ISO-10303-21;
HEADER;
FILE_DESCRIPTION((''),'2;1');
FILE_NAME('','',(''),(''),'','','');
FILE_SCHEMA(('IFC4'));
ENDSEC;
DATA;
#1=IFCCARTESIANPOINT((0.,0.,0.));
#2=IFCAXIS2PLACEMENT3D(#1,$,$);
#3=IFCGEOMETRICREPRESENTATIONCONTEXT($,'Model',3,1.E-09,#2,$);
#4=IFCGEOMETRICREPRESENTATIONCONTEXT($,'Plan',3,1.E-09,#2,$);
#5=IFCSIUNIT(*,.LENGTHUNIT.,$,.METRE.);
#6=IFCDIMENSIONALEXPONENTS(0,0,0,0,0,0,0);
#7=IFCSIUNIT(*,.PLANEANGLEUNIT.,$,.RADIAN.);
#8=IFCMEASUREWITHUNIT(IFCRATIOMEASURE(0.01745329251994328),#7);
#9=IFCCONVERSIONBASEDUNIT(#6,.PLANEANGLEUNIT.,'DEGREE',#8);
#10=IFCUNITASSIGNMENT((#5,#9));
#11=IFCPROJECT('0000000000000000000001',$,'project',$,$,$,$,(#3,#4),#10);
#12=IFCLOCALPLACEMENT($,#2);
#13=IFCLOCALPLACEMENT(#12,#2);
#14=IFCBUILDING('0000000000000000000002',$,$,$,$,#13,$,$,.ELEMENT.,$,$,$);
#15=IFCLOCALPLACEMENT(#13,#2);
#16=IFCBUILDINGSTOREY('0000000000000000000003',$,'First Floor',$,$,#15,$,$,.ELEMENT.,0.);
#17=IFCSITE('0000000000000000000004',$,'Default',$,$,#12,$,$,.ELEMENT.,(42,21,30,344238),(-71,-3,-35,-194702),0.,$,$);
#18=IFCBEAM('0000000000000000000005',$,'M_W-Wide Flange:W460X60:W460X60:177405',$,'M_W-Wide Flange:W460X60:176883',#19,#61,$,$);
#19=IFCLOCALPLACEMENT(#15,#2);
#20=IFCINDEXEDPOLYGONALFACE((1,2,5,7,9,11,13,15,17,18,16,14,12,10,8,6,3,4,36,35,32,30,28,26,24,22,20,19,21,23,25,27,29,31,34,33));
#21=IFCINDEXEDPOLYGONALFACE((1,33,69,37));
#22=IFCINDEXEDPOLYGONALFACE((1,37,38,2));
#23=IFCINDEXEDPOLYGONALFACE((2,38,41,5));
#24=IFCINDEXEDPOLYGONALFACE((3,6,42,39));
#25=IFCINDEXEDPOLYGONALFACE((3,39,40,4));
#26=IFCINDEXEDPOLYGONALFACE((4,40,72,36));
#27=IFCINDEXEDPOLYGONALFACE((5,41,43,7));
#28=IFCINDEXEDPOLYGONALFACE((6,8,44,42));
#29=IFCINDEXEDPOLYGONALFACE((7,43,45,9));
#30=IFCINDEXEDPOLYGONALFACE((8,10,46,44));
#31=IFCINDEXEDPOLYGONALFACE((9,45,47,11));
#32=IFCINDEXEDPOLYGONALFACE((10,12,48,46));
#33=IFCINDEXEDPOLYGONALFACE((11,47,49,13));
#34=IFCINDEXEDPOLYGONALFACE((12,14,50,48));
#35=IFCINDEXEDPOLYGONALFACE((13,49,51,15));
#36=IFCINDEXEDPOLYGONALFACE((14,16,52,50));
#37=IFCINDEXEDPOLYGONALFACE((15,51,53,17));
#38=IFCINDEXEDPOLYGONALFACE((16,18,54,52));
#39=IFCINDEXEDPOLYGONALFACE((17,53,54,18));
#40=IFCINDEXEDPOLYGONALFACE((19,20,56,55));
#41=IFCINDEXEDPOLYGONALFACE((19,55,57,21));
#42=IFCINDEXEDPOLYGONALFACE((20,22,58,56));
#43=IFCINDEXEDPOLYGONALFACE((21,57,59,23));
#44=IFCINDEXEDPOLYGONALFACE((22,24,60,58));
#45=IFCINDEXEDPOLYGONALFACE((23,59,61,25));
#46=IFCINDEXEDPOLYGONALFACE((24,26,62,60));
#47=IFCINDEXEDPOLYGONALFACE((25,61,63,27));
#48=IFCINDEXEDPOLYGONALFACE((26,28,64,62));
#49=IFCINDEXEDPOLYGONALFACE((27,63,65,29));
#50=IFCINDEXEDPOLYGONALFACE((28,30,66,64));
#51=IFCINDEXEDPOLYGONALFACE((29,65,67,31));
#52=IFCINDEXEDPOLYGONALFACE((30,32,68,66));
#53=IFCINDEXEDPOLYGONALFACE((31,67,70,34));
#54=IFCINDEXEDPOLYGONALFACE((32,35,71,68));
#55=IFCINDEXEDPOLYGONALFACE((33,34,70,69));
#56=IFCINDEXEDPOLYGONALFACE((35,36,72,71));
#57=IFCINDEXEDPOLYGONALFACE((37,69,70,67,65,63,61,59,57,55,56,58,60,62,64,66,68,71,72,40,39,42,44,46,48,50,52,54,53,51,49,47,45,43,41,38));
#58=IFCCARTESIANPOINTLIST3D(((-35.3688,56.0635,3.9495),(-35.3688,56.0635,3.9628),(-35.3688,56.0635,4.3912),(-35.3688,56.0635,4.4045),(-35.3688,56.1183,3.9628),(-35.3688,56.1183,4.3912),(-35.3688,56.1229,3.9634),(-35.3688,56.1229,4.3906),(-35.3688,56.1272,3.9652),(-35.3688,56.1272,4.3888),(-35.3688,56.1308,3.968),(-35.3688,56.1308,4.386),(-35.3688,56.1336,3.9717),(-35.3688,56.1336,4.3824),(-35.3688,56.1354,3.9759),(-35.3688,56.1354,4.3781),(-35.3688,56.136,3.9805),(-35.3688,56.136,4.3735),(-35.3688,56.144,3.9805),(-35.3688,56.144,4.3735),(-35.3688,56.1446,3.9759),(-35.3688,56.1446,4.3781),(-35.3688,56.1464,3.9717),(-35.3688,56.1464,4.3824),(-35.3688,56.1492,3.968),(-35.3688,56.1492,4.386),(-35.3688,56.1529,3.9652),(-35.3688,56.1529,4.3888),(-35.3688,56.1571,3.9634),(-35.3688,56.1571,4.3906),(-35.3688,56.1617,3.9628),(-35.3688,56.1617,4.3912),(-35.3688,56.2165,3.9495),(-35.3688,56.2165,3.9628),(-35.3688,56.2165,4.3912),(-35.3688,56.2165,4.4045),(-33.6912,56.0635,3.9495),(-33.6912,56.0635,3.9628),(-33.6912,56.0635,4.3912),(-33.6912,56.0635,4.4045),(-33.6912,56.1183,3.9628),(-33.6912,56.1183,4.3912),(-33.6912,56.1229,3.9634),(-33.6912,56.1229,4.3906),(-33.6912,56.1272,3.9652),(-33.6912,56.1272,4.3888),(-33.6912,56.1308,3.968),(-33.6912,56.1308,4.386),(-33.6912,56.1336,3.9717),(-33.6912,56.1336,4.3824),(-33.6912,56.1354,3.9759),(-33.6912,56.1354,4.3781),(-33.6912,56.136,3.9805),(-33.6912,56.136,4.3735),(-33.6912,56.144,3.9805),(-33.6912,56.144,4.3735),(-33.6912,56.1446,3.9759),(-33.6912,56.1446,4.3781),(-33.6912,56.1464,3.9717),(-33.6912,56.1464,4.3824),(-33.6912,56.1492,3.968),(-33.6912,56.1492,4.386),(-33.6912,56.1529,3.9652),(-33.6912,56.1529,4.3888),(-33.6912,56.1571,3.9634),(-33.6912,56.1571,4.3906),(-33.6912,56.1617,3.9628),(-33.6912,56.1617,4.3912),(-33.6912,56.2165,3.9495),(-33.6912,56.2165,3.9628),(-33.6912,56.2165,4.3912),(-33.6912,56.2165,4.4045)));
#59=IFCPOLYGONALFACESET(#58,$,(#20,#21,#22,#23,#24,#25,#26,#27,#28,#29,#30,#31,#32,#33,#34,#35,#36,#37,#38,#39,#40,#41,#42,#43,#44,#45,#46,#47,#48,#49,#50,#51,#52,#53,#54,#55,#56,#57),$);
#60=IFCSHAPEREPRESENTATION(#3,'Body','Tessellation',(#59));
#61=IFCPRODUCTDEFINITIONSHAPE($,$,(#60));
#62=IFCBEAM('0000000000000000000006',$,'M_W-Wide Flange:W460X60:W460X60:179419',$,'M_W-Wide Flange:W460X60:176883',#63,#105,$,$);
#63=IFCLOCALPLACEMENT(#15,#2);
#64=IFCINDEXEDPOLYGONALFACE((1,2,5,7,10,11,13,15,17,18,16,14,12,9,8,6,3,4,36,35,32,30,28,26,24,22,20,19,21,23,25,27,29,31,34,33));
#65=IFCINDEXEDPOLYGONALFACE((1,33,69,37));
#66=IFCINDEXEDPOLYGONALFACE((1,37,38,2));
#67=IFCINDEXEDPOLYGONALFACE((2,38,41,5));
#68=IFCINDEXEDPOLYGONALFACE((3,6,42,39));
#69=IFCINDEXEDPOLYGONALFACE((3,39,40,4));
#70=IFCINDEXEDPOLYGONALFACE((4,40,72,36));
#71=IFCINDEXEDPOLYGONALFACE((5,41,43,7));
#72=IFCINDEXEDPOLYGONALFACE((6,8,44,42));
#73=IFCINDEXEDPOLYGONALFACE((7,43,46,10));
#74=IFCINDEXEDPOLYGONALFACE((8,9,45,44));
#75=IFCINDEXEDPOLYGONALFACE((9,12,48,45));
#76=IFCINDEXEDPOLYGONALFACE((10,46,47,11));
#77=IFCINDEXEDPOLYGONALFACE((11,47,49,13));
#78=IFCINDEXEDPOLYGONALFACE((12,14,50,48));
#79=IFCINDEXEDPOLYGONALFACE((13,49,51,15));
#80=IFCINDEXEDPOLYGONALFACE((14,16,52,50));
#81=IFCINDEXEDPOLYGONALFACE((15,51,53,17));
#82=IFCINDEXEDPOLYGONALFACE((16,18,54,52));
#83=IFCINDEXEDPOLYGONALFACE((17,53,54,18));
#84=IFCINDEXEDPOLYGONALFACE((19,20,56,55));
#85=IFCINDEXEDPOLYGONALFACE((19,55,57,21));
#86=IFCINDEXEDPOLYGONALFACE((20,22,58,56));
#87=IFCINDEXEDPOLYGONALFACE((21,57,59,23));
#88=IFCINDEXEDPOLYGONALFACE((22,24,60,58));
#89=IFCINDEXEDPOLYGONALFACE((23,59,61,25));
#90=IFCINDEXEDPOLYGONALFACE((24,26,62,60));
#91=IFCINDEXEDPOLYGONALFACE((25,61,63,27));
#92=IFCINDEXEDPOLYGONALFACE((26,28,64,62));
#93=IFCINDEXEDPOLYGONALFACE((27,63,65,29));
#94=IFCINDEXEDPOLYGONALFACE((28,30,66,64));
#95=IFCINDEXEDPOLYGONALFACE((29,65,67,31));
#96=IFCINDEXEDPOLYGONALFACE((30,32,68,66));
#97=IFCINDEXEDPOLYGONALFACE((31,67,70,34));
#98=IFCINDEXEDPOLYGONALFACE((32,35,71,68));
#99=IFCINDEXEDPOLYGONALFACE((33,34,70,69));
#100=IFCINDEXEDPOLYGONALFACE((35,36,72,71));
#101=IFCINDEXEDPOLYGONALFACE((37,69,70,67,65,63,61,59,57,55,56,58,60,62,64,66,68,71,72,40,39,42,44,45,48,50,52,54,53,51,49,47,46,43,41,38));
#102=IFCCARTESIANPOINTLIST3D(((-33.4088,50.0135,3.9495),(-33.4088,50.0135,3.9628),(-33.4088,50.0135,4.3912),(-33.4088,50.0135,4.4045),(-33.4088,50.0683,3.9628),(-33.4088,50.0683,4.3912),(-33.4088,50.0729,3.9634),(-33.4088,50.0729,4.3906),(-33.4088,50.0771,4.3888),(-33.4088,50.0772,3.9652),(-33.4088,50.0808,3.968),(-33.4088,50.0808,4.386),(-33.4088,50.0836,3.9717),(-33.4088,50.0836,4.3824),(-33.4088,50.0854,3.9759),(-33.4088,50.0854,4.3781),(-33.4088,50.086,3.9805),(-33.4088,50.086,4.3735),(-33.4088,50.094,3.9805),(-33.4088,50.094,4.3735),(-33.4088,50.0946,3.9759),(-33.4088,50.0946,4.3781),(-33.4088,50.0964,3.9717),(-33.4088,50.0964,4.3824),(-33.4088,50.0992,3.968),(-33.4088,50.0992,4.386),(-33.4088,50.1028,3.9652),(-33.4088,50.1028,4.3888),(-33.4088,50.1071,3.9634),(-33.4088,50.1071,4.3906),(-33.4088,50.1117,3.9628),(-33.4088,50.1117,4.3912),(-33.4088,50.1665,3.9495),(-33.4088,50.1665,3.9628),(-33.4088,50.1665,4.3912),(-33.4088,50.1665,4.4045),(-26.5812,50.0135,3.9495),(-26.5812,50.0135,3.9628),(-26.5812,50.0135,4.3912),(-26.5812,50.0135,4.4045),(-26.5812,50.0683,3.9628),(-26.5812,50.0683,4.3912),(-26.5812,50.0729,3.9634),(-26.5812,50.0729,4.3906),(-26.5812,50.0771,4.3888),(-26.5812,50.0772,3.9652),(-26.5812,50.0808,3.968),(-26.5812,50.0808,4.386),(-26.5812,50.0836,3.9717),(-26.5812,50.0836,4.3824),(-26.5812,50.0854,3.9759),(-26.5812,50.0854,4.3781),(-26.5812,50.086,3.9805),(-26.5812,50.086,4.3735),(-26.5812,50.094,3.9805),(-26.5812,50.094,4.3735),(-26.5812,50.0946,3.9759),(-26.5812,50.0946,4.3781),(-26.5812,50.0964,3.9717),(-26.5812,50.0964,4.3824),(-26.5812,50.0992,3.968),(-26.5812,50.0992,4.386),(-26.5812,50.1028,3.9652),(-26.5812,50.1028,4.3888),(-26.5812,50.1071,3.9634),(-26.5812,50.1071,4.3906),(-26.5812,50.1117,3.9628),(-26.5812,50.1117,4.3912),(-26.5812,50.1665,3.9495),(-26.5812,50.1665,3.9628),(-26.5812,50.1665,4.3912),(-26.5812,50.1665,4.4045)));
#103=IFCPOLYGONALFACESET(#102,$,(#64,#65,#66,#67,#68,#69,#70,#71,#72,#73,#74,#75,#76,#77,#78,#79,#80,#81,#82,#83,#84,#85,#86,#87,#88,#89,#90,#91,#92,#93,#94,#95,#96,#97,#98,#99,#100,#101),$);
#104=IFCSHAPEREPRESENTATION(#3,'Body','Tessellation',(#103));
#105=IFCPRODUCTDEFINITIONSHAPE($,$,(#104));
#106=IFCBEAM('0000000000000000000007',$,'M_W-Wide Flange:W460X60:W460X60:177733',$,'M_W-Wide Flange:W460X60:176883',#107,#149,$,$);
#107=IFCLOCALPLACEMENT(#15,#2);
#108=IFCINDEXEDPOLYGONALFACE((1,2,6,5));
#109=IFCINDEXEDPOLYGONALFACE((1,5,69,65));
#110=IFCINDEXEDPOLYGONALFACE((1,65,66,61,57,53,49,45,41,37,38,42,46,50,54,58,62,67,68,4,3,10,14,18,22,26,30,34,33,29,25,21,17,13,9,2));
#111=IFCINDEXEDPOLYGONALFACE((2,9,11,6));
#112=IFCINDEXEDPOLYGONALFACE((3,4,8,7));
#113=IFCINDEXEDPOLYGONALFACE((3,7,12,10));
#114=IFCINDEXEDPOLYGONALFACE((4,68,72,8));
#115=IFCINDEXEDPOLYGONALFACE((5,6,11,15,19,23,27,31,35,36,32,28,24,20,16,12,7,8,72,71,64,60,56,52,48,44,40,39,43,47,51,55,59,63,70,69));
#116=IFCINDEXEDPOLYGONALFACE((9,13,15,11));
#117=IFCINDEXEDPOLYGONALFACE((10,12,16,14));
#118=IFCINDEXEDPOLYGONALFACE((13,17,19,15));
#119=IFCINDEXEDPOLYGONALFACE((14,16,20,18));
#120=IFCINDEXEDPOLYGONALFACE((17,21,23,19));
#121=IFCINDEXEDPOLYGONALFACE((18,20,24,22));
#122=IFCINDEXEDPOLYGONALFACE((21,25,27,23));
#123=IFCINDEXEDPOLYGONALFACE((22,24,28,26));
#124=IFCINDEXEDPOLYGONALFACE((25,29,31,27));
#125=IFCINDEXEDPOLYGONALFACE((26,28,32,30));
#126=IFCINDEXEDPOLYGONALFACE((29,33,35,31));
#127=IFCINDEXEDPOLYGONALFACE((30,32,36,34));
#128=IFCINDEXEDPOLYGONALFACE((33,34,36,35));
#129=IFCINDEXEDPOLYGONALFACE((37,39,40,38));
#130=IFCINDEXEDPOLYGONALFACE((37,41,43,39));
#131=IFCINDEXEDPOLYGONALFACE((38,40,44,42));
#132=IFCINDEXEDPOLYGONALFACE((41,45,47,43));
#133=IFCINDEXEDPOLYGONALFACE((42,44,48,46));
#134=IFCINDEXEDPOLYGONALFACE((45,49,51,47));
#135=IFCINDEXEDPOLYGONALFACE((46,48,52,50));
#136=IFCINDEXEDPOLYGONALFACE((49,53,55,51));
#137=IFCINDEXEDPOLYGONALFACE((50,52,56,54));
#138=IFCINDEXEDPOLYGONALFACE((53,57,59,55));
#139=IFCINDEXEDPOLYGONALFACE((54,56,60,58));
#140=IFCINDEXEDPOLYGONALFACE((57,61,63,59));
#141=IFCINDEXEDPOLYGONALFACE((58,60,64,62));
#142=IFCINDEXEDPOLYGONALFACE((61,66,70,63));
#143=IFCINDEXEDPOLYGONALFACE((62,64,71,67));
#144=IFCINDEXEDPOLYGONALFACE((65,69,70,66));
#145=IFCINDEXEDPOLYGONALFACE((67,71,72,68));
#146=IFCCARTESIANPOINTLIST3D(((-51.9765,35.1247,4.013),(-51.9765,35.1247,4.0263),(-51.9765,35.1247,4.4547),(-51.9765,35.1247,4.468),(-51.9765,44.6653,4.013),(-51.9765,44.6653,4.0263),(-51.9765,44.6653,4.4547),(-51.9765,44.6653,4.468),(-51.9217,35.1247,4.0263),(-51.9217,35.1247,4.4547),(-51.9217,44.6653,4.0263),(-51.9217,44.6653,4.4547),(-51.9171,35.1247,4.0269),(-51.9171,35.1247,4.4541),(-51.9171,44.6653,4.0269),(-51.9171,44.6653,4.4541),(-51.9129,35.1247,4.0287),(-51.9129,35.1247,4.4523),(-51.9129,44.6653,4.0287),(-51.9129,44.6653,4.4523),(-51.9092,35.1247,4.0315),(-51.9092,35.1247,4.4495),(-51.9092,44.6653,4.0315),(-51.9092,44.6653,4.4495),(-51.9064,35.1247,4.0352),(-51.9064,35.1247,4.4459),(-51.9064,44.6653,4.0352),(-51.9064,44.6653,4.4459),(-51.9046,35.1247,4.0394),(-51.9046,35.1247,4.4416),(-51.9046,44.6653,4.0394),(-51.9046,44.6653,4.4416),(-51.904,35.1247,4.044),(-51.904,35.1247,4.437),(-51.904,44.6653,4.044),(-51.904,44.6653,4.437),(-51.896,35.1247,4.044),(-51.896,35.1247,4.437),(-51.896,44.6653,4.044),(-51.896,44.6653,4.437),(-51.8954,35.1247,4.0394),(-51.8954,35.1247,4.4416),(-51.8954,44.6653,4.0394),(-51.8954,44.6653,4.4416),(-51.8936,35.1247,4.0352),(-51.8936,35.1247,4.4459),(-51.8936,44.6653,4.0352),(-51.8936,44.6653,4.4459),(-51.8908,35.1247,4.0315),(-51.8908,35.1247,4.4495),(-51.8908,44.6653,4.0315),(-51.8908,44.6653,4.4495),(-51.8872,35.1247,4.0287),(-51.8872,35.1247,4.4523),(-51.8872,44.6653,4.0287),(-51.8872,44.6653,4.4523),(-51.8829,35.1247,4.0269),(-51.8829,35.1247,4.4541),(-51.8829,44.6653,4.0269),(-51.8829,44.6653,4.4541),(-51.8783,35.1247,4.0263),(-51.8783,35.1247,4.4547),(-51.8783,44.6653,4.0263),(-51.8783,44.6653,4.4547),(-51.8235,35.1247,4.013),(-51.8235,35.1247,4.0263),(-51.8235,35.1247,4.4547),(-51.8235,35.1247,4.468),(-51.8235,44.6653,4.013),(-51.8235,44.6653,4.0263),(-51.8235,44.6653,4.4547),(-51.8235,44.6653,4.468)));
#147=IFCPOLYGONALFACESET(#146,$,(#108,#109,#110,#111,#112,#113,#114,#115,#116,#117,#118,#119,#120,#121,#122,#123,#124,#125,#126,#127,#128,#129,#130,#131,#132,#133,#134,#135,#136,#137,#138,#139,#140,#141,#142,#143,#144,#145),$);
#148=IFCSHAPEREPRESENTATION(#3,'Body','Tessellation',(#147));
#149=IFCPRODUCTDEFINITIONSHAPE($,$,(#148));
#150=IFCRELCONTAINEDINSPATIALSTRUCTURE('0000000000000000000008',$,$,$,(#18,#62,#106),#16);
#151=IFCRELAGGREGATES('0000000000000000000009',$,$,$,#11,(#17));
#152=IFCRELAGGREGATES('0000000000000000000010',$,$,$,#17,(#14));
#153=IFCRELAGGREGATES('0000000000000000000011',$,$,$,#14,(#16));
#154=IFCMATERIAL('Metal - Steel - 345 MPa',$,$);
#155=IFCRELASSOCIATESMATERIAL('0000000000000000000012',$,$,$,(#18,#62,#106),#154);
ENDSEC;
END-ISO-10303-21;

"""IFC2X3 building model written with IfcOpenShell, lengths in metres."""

from ifc_helpers import new_model, entity, si_unit, converted_unit, frame, frame_2d, origin, place, context, project, spatial, polyline, circle_curve, parameter, trimmed, segment, composite_curve, outline, extrude, material, element, save


model = new_model("IFC2X3")

# Units and contexts
model_context = context("Model", 3, precision=1e-09, world=origin())
plan_context = context("Plan", 3, precision=1e-09, world=origin())
ifc_project = project(units=[si_unit("LENGTHUNIT", "METRE"), converted_unit("PLANEANGLEUNIT", "DEGREE", entity("IfcRatioMeasure", 0.01745329251994328), si_unit("PLANEANGLEUNIT", "RADIAN"), dimensions=[0, 0, 0, 0, 0, 0, 0])], contexts=[model_context, plan_context])

# Site, building, storey
site_placement = place(None, origin())
site = spatial("IfcSite", under=ifc_project, at=site_placement, Name="Default", CompositionType="ELEMENT", RefLatitude=(42, 21, 30, 344238), RefLongitude=(-71, -3, -35, -194702), RefElevation=0.0)
building_placement = place(site_placement, origin())
building = spatial("IfcBuilding", under=site, at=building_placement, CompositionType="ELEMENT")
storey_placement = place(building_placement, origin())
storey = spatial("IfcBuildingStorey", under=building, at=storey_placement, Name="First Floor", CompositionType="ELEMENT", Elevation=0.0)

# Beams
ifc_material = material(Name="Metal - Steel - 345 MPa")
beam_1_placement = place(storey_placement, frame((-35.503, 56.14, 4.4045), z_axis=(0.0, 0.0, 1.0), x_axis=(0.0, -1.0, 0.0)))
element("IfcBeam", 1, at=beam_1_placement, inside=storey, material=ifc_material, Name="M_W-Wide Flange:W460X60:W460X60:177405", ObjectType="M_W-Wide Flange:W460X60:176883", context=model_context, shape_type="SweptSolid", body=[
    extrude(outline(composite_curve([segment(polyline([(-0.0765, -0.2142), (-0.0765, -0.2275)]), True, "CONTINUOUS"), segment(polyline([(-0.0765, -0.2275), (0.0765, -0.2275)]), True, "CONTINUOUS"), segment(polyline([(0.0765, -0.2275), (0.0765, -0.2142)]), True, "CONTINUOUS"), segment(polyline([(0.0765, -0.2142), (0.0217, -0.2142)]), True, "CONTINUOUS"), segment(trimmed(circle_curve(frame_2d((0.0217, -0.1965), x_axis=(0.0, -1.0)), 0.0177), [parameter(270.0)], [parameter(360.0)], True, "PARAMETER"), False, "CONTINUOUS"), segment(polyline([(0.004, -0.1965), (0.004, 0.1965)]), True, "CONTINUOUS"), segment(trimmed(circle_curve(frame_2d((0.0217, 0.1965), x_axis=(-1.0, 0.0)), 0.0177), [parameter(270.0)], [parameter(360.0)], True, "PARAMETER"), False, "CONTINUOUS"), segment(polyline([(0.0217, 0.2142), (0.0765, 0.2142)]), True, "CONTINUOUS"), segment(polyline([(0.0765, 0.2142), (0.0765, 0.2275)]), True, "CONTINUOUS"), segment(polyline([(0.0765, 0.2275), (-0.0765, 0.2275)]), True, "CONTINUOUS"), segment(polyline([(-0.0765, 0.2275), (-0.0765, 0.2142)]), True, "CONTINUOUS"), segment(polyline([(-0.0765, 0.2142), (-0.0217, 0.2142)]), True, "CONTINUOUS"), segment(trimmed(circle_curve(frame_2d((-0.0217, 0.1965), x_axis=(0.0, 1.0)), 0.0177), [parameter(270.0)], [parameter(360.0)], True, "PARAMETER"), False, "CONTINUOUS"), segment(polyline([(-0.004, 0.1965), (-0.004, -0.1965)]), True, "CONTINUOUS"), segment(trimmed(circle_curve(frame_2d((-0.0217, -0.1965), x_axis=(1.0, 0.0)), 0.0177), [parameter(270.0)], [parameter(0.0)], True, "PARAMETER"), False, "CONTINUOUS"), segment(polyline([(-0.0217, -0.2142), (-0.0765, -0.2142)]), True, "CONTINUOUS")], self_intersect=False)), frame((0.0, 0.1342, -0.2275), z_axis=(0.0, -1.0, 0.0), x_axis=(1.0, 0.0, 0.0)), (0.0, 0.0, -1.0), 1.6776),
])
beam_2_placement = place(storey_placement, frame((-33.5519, 50.09, 4.4045), z_axis=(0.0, 0.0, 1.0), x_axis=(0.0, -1.0, 0.0)))
element("IfcBeam", 2, at=beam_2_placement, inside=storey, material=ifc_material, Name="M_W-Wide Flange:W460X60:W460X60:179419", ObjectType="M_W-Wide Flange:W460X60:176883", context=model_context, shape_type="SweptSolid", body=[
    extrude(outline(composite_curve([segment(polyline([(-0.0765, -0.2142), (-0.0765, -0.2275)]), True, "CONTINUOUS"), segment(polyline([(-0.0765, -0.2275), (0.0765, -0.2275)]), True, "CONTINUOUS"), segment(polyline([(0.0765, -0.2275), (0.0765, -0.2142)]), True, "CONTINUOUS"), segment(polyline([(0.0765, -0.2142), (0.0217, -0.2142)]), True, "CONTINUOUS"), segment(trimmed(circle_curve(frame_2d((0.0217, -0.1965), x_axis=(0.0, -1.0)), 0.0177), [parameter(270.0)], [parameter(360.0)], True, "PARAMETER"), False, "CONTINUOUS"), segment(polyline([(0.004, -0.1965), (0.004, 0.1965)]), True, "CONTINUOUS"), segment(trimmed(circle_curve(frame_2d((0.0217, 0.1965), x_axis=(-1.0, 0.0)), 0.0177), [parameter(270.0)], [parameter(360.0)], True, "PARAMETER"), False, "CONTINUOUS"), segment(polyline([(0.0217, 0.2142), (0.0765, 0.2142)]), True, "CONTINUOUS"), segment(polyline([(0.0765, 0.2142), (0.0765, 0.2275)]), True, "CONTINUOUS"), segment(polyline([(0.0765, 0.2275), (-0.0765, 0.2275)]), True, "CONTINUOUS"), segment(polyline([(-0.0765, 0.2275), (-0.0765, 0.2142)]), True, "CONTINUOUS"), segment(polyline([(-0.0765, 0.2142), (-0.0217, 0.2142)]), True, "CONTINUOUS"), segment(trimmed(circle_curve(frame_2d((-0.0217, 0.1965), x_axis=(0.0, 1.0)), 0.0177), [parameter(270.0)], [parameter(360.0)], True, "PARAMETER"), False, "CONTINUOUS"), segment(polyline([(-0.004, 0.1965), (-0.004, -0.1965)]), True, "CONTINUOUS"), segment(trimmed(circle_curve(frame_2d((-0.0217, -0.1965), x_axis=(1.0, 0.0)), 0.0177), [parameter(270.0)], [parameter(0.0)], True, "PARAMETER"), False, "CONTINUOUS"), segment(polyline([(-0.0217, -0.2142), (-0.0765, -0.2142)]), True, "CONTINUOUS")], self_intersect=False)), frame((0.0, 0.1431, -0.2275), z_axis=(0.0, -1.0, 0.0), x_axis=(1.0, 0.0, 0.0)), (0.0, 0.0, -1.0), 6.8276),
])
beam_3_placement = place(storey_placement, frame((-51.9, 44.7814, 4.468), z_axis=(0.0, 0.0, 1.0), x_axis=(-1.0, 0.0, 0.0)))
element("IfcBeam", 3, at=beam_3_placement, inside=storey, material=ifc_material, Name="M_W-Wide Flange:W460X60:W460X60:177733", ObjectType="M_W-Wide Flange:W460X60:176883", context=model_context, shape_type="SweptSolid", body=[
    extrude(outline(composite_curve([segment(polyline([(0.2142, -0.0765), (0.2275, -0.0765)]), True, "CONTINUOUS"), segment(polyline([(0.2275, -0.0765), (0.2275, 0.0765)]), True, "CONTINUOUS"), segment(polyline([(0.2275, 0.0765), (0.2142, 0.0765)]), True, "CONTINUOUS"), segment(polyline([(0.2142, 0.0765), (0.2142, 0.0217)]), True, "CONTINUOUS"), segment(trimmed(circle_curve(frame_2d((0.1965, 0.0217), x_axis=(1.0, 0.0)), 0.0177), [parameter(270.0)], [parameter(360.0)], True, "PARAMETER"), False, "CONTINUOUS"), segment(polyline([(0.1965, 0.004), (-0.1965, 0.004)]), True, "CONTINUOUS"), segment(trimmed(circle_curve(frame_2d((-0.1965, 0.0217), x_axis=(0.0, -1.0)), 0.0177), [parameter(270.0)], [parameter(360.0)], True, "PARAMETER"), False, "CONTINUOUS"), segment(polyline([(-0.2142, 0.0217), (-0.2142, 0.0765)]), True, "CONTINUOUS"), segment(polyline([(-0.2142, 0.0765), (-0.2275, 0.0765)]), True, "CONTINUOUS"), segment(polyline([(-0.2275, 0.0765), (-0.2275, -0.0765)]), True, "CONTINUOUS"), segment(polyline([(-0.2275, -0.0765), (-0.2142, -0.0765)]), True, "CONTINUOUS"), segment(polyline([(-0.2142, -0.0765), (-0.2142, -0.0217)]), True, "CONTINUOUS"), segment(trimmed(circle_curve(frame_2d((-0.1965, -0.0217), x_axis=(-1.0, 0.0)), 0.0177), [parameter(270.0)], [parameter(360.0)], True, "PARAMETER"), False, "CONTINUOUS"), segment(polyline([(-0.1965, -0.004), (0.1965, -0.004)]), True, "CONTINUOUS"), segment(trimmed(circle_curve(frame_2d((0.1965, -0.0217), x_axis=(0.0, 1.0)), 0.0177), [parameter(270.0)], [parameter(0.0)], True, "PARAMETER"), False, "CONTINUOUS"), segment(polyline([(0.2142, -0.0217), (0.2142, -0.0765)]), True, "CONTINUOUS")], self_intersect=False)), frame((0.0, 9.6567, -0.2275), z_axis=(0.0, -1.0, 0.0), x_axis=(0.0, 0.0, -1.0)), (0.0, 0.0, 1.0), 9.5406),
])

save(model, "model.ifc")
